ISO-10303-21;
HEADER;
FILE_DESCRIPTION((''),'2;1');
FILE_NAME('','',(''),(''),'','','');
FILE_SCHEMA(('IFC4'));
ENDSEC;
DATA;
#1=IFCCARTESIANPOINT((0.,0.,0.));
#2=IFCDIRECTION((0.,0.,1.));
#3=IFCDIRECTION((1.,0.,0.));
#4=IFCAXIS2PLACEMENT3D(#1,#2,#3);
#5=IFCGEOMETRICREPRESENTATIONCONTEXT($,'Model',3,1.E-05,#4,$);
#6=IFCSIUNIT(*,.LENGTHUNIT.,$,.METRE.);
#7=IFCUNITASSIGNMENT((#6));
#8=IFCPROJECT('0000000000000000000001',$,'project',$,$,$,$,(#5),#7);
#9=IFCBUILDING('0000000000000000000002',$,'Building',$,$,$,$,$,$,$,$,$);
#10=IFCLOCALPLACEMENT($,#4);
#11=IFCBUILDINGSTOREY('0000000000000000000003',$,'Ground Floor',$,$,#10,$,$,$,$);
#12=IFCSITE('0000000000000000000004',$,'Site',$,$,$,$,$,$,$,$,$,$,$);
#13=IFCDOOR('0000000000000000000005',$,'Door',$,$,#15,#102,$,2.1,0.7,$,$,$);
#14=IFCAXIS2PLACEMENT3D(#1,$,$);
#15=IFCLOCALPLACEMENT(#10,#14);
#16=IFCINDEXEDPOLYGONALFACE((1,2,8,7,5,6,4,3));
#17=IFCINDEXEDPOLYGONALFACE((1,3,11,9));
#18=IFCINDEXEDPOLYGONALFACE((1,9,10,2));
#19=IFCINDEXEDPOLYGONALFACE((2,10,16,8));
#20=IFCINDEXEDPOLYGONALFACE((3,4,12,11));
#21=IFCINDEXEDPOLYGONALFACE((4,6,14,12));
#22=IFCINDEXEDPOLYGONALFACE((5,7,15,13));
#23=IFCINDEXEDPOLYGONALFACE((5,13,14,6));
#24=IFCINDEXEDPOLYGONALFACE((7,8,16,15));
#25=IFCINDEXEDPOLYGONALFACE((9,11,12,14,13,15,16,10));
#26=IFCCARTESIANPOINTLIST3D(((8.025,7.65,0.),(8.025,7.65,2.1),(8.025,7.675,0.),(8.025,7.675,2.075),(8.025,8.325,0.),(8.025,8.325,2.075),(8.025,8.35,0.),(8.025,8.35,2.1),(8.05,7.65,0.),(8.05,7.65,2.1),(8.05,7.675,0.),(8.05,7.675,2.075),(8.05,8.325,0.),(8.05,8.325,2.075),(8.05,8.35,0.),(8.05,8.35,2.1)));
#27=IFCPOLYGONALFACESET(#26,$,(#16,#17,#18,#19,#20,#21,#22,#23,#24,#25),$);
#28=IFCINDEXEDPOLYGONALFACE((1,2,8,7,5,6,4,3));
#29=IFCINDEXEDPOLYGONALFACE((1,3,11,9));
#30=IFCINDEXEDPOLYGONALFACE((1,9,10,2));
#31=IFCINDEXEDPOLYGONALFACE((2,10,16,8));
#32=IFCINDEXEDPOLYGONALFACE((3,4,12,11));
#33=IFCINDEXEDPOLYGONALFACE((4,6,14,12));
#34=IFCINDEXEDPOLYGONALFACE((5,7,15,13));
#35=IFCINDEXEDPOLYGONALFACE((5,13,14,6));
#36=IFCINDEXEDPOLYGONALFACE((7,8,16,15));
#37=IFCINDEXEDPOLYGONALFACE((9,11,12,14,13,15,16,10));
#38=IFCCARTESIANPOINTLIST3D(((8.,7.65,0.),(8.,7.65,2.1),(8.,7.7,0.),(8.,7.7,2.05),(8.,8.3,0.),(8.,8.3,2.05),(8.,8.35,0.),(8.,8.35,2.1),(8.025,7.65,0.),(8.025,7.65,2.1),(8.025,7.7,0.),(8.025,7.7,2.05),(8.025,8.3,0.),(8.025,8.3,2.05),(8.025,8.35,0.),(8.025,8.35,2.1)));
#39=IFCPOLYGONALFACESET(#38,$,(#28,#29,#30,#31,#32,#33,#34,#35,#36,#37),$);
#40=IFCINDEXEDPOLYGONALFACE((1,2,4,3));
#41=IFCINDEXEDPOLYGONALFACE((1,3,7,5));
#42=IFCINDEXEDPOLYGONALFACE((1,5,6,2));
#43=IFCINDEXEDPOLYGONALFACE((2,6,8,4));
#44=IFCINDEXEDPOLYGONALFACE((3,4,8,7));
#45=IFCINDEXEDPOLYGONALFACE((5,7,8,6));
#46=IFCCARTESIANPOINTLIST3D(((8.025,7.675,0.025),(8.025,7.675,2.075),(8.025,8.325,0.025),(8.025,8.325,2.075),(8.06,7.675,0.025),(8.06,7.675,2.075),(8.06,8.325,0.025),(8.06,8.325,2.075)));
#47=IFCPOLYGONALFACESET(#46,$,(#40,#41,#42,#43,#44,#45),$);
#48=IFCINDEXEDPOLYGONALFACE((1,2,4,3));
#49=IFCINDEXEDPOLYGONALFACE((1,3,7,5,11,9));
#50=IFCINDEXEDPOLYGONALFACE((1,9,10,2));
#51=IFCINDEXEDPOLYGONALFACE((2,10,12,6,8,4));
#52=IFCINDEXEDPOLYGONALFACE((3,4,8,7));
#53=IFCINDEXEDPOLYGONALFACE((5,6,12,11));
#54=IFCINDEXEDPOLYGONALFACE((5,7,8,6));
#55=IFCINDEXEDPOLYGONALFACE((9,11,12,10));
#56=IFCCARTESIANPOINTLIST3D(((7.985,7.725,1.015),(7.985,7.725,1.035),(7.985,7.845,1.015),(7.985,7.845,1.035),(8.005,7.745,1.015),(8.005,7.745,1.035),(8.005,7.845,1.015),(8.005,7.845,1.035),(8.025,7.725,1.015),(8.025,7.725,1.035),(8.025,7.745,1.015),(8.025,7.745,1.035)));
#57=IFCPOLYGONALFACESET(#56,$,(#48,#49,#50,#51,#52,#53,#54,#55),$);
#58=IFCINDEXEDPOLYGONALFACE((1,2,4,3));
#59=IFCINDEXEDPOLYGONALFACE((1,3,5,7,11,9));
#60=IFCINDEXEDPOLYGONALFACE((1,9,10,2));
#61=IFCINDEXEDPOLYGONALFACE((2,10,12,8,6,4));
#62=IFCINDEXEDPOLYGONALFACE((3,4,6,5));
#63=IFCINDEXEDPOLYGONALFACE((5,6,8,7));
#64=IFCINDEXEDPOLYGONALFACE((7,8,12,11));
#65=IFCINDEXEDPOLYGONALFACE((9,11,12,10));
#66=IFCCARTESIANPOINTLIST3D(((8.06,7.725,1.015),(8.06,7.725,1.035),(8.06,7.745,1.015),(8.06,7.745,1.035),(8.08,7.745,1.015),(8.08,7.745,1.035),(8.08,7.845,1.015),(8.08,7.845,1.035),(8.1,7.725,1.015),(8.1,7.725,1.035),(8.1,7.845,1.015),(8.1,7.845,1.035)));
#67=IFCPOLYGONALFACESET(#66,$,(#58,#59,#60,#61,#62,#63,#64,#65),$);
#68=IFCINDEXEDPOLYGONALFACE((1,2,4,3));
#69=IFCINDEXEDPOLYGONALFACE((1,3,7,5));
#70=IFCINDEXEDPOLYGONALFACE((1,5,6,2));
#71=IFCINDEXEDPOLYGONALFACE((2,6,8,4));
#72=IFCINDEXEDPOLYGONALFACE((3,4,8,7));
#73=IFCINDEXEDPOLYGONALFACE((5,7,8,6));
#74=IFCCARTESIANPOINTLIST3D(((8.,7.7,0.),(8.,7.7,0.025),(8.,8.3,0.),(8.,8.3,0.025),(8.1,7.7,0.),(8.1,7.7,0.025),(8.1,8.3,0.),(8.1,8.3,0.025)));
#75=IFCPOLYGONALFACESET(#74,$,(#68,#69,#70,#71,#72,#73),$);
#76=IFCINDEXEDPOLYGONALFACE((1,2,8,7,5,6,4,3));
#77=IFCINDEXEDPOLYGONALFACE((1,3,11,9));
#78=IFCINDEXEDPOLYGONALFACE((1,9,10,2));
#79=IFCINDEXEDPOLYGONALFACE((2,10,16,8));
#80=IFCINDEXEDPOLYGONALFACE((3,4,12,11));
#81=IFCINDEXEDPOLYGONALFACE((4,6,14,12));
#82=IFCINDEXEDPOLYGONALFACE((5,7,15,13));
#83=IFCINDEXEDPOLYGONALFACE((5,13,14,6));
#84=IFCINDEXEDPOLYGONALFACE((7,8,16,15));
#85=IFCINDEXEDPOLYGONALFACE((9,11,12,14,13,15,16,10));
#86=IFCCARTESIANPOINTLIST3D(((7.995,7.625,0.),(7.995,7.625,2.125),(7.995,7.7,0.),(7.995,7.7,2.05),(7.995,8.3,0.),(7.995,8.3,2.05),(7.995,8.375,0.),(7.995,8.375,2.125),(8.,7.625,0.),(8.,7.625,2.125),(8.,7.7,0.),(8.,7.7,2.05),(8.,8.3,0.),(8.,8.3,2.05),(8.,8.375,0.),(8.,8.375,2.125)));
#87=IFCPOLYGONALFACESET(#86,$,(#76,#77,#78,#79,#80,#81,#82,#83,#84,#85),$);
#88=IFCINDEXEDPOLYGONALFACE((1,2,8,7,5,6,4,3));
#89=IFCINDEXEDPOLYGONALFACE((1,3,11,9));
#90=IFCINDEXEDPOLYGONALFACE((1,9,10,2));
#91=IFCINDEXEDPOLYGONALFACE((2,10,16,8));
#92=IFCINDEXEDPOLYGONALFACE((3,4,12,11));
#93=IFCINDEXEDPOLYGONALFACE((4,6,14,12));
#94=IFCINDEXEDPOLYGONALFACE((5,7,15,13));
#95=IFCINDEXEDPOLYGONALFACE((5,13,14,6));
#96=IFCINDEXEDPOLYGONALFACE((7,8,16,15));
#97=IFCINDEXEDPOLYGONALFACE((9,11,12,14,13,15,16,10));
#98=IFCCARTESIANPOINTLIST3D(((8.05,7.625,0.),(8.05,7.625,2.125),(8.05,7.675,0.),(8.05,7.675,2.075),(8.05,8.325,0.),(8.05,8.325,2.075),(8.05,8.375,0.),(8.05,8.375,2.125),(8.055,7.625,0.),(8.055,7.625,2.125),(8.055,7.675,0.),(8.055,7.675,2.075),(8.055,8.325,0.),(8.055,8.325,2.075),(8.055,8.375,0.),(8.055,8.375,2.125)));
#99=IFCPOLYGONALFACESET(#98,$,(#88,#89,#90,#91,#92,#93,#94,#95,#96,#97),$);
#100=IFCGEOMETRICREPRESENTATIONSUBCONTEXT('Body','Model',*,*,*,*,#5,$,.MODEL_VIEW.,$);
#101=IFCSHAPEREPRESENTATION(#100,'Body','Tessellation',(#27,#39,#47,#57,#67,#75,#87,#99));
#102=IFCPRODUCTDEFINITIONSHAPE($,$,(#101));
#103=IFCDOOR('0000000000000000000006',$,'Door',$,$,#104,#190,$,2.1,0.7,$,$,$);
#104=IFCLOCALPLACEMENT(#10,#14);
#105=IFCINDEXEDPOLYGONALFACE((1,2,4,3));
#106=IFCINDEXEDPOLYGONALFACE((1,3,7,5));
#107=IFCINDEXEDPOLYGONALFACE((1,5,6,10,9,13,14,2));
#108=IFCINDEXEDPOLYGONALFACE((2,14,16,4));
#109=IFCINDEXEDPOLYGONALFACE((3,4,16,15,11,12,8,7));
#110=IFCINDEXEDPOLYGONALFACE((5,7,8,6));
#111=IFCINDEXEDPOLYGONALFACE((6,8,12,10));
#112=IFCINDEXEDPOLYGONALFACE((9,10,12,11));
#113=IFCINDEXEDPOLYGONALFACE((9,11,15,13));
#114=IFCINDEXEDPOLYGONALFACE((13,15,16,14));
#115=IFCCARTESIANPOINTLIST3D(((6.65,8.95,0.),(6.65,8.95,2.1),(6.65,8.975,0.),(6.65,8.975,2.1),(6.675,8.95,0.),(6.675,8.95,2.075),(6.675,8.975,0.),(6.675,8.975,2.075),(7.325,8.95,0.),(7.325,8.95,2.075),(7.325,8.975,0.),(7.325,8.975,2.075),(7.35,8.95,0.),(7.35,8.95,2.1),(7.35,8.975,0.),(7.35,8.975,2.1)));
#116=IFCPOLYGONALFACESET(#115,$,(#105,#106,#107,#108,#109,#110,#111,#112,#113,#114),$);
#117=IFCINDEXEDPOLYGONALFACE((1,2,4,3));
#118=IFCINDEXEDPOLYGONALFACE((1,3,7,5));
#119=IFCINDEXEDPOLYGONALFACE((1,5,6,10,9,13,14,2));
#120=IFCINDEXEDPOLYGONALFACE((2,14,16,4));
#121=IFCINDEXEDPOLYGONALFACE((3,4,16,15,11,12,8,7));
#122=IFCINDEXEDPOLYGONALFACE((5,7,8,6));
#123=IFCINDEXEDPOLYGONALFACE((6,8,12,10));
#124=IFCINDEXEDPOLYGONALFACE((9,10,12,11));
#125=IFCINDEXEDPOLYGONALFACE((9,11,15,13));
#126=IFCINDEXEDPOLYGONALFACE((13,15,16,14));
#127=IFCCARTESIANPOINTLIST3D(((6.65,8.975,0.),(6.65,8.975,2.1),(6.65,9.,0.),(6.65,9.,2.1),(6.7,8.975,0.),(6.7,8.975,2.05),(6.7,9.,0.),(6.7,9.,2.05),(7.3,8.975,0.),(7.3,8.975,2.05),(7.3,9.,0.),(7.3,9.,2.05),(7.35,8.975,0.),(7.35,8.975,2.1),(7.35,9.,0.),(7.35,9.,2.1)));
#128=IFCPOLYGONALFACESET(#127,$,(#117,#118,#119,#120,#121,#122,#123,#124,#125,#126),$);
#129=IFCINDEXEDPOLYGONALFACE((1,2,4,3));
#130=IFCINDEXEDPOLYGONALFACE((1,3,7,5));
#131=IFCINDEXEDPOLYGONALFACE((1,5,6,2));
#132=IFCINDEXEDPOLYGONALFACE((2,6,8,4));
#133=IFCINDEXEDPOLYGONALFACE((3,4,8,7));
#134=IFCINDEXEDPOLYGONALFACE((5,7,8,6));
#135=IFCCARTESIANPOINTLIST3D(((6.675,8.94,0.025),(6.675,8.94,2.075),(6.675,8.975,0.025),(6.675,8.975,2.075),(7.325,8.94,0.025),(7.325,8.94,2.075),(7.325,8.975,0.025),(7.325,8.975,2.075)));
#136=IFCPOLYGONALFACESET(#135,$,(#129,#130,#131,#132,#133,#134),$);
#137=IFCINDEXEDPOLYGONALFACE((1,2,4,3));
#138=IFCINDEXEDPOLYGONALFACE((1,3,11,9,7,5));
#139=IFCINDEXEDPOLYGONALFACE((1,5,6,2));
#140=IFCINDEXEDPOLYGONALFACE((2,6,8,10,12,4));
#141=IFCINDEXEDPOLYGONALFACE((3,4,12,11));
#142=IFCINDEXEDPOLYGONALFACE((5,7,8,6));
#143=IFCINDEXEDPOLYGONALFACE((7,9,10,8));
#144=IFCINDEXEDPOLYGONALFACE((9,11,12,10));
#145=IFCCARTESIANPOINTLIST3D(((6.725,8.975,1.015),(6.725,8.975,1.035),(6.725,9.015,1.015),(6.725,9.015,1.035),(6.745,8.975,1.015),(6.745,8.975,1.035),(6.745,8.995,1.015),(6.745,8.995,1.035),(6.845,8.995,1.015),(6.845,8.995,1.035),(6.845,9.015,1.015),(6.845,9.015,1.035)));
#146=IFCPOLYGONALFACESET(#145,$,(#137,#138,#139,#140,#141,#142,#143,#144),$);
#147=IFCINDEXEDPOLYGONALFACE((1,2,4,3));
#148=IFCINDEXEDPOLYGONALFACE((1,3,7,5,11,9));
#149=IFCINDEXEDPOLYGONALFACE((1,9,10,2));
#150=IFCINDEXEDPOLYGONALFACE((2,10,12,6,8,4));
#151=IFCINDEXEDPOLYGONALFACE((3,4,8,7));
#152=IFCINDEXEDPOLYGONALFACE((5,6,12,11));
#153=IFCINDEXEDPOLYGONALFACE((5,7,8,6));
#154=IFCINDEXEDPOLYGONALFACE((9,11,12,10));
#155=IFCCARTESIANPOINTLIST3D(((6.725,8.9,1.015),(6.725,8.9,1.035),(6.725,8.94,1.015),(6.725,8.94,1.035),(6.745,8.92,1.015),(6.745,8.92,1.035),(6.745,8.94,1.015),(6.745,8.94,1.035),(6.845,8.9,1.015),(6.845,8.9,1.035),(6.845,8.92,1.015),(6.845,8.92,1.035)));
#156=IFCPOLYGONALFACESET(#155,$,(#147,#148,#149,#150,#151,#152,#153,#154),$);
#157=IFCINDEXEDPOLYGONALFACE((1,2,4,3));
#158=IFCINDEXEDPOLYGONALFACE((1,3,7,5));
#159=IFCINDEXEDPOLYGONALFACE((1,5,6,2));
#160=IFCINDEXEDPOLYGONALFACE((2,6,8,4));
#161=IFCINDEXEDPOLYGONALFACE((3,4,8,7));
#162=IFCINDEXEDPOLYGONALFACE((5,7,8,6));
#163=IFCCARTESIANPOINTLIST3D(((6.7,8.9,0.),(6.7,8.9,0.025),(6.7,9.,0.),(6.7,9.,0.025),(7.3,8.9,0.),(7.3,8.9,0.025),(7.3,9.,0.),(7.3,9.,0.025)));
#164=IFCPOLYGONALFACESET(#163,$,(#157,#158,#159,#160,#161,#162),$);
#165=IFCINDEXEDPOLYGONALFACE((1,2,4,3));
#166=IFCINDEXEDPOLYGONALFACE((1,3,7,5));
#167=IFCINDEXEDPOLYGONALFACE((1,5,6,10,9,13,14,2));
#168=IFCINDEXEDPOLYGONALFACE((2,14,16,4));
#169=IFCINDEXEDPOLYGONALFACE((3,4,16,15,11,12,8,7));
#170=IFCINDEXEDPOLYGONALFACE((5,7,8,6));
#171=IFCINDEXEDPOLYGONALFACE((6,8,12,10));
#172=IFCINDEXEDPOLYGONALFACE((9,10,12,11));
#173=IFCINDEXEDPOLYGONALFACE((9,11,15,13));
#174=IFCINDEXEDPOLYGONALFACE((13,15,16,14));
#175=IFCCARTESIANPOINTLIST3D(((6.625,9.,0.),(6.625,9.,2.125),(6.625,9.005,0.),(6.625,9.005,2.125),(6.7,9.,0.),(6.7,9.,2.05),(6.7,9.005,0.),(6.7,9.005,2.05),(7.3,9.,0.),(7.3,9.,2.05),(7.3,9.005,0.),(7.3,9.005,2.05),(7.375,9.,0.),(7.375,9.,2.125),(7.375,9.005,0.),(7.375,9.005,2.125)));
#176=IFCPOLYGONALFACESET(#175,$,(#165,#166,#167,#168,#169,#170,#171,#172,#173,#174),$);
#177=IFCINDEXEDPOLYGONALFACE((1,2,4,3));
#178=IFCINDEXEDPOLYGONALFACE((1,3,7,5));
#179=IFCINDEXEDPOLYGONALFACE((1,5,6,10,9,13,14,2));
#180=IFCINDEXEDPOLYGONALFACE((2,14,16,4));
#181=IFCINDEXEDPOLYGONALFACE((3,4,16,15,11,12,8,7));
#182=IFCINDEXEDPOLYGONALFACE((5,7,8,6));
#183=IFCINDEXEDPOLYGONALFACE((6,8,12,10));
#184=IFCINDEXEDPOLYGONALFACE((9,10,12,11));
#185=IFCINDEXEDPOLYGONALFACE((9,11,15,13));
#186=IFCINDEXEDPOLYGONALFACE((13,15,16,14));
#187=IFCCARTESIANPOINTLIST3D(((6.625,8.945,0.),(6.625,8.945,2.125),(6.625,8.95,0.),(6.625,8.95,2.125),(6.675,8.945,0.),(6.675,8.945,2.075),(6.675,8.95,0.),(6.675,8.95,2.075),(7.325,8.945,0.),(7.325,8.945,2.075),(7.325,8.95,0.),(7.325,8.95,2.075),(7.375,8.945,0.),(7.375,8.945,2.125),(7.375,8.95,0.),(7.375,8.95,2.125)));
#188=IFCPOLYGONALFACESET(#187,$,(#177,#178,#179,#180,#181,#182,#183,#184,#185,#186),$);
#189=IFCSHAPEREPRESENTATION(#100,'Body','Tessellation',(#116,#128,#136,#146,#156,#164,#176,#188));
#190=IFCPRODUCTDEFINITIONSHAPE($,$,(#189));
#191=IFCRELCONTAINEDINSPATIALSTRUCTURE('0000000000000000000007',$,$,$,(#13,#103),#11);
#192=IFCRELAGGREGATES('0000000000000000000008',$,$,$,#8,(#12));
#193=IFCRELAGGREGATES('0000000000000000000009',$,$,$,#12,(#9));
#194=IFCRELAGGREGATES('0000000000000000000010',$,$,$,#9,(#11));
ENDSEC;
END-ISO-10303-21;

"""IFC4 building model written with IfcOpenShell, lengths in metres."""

from ifc_helpers import new_model, si_unit, frame, origin_with_axes, place, context, subcontext, project, spatial, line, indexed_curve, outline, extrude, element, save


model = new_model("IFC4")

# Units and contexts
model_context = context("Model", 3, precision=1e-05, world=origin_with_axes())
body_context = subcontext(model_context, "Body", "Model", "MODEL_VIEW")
ifc_project = project(units=[si_unit("LENGTHUNIT", "METRE")], contexts=[model_context])

# Site, building, storey
site = spatial("IfcSite", under=ifc_project, Name="Site")
building = spatial("IfcBuilding", under=site, Name="Building")
storey_placement = place(None, origin_with_axes())
storey = spatial("IfcBuildingStorey", under=building, at=storey_placement, Name="Ground Floor")

# Doors
door_1_placement = place(storey_placement, frame((8.0, 8.35, 0.0), z_axis=(0.0, 0.0, 1.0), x_axis=(0.0, -1.0, 0.0)))
element("IfcDoor", 1, at=door_1_placement, inside=storey, Name="Door", OverallHeight=2.1, OverallWidth=0.7, context=body_context, shape_type="SweptSolid", body=[
    extrude(outline(indexed_curve([(0.0, 0.0), (0.0, 2.1), (0.7, 2.1), (0.7, 0.0), (0.675, 0.0), (0.675, 2.075), (0.025, 2.075), (0.025, 0.0)], segments=[line(1, 2, 3, 4, 5, 6, 7, 8, 1)])), frame((0.0, 0.025, 0.0), z_axis=(0.0, -1.0, 0.0), x_axis=(1.0, 0.0, 0.0)), (0.0, 0.0, -1.0), 0.025),
    extrude(outline(indexed_curve([(0.0, 0.0), (0.0, 2.1), (0.7, 2.1), (0.7, 0.0), (0.65, 0.0), (0.65, 2.05), (0.05, 2.05), (0.05, 0.0)], segments=[line(1, 2, 3, 4, 5, 6, 7, 8, 1)])), frame((0.0, 0.0, 0.0), z_axis=(0.0, -1.0, 0.0), x_axis=(1.0, 0.0, 0.0)), (0.0, 0.0, -1.0), 0.025),
    extrude(outline(indexed_curve([(0.0, 0.0), (0.65, 0.0), (0.65, 0.035), (0.0, 0.035)], segments=[line(1, 2, 3, 4, 1)])), frame((0.025, 0.025, 0.025), z_axis=(0.0, 0.0, 1.0), x_axis=(1.0, 0.0, 0.0)), (0.0, 0.0, 1.0), 2.05),
    extrude(outline(indexed_curve([(0.0, 0.0), (0.0, -0.04), (-0.12, -0.04), (-0.12, -0.02), (-0.02, -0.02), (-0.02, 0.0)], segments=[line(1, 2, 3, 4, 5, 6, 1)])), frame((0.625, 0.025, 1.015), z_axis=(0.0, 0.0, 1.0), x_axis=(1.0, 0.0, 0.0)), (0.0, 0.0, 1.0), 0.02),
    extrude(outline(indexed_curve([(0.0, 0.0), (0.0, 0.04), (-0.12, 0.04), (-0.12, 0.02), (-0.02, 0.02), (-0.02, 0.0)], segments=[line(1, 2, 3, 4, 5, 6, 1)])), frame((0.625, 0.06, 1.015), z_axis=(0.0, 0.0, 1.0), x_axis=(1.0, 0.0, 0.0)), (0.0, 0.0, 1.0), 0.02),
    extrude(outline(indexed_curve([(0.0, 0.0), (0.6, 0.0), (0.6, 0.1), (0.0, 0.1)], segments=[line(1, 2, 3, 4, 1)])), frame((0.05, 0.0, 0.0), z_axis=(0.0, 0.0, 1.0), x_axis=(1.0, 0.0, 0.0)), (0.0, 0.0, 1.0), 0.025),
    extrude(outline(indexed_curve([(0.0, 0.0), (0.0, 2.125), (0.75, 2.125), (0.75, 0.0), (0.675, 0.0), (0.675, 2.05), (0.075, 2.05), (0.075, 0.0)], segments=[line(1, 2, 3, 4, 5, 6, 7, 8, 1)])), frame((-0.025, -0.005, 0.0), z_axis=(0.0, -1.0, 0.0), x_axis=(1.0, 0.0, 0.0)), (0.0, 0.0, -1.0), 0.005),
    extrude(outline(indexed_curve([(0.0, 0.0), (0.0, 2.125), (0.75, 2.125), (0.75, 0.0), (0.7, 0.0), (0.7, 2.075), (0.05, 2.075), (0.05, 0.0)], segments=[line(1, 2, 3, 4, 5, 6, 7, 8, 1)])), frame((-0.025, 0.05, 0.0), z_axis=(0.0, -1.0, 0.0), x_axis=(1.0, 0.0, 0.0)), (0.0, 0.0, -1.0), 0.005),
])
door_2_placement = place(storey_placement, frame((7.35, 9.0, 0.0), z_axis=(0.0, 0.0, 1.0), x_axis=(-1.0, 0.0, 0.0)))
element("IfcDoor", 2, at=door_2_placement, inside=storey, Name="Door", OverallHeight=2.1, OverallWidth=0.7, context=body_context, shape_type="SweptSolid", body=[
    extrude(outline(indexed_curve([(0.0, 0.0), (0.0, 2.1), (0.7, 2.1), (0.7, 0.0), (0.675, 0.0), (0.675, 2.075), (0.025, 2.075), (0.025, 0.0)], segments=[line(1, 2, 3, 4, 5, 6, 7, 8, 1)])), frame((0.0, 0.025, 0.0), z_axis=(0.0, -1.0, 0.0), x_axis=(1.0, 0.0, 0.0)), (0.0, 0.0, -1.0), 0.025),
    extrude(outline(indexed_curve([(0.0, 0.0), (0.0, 2.1), (0.7, 2.1), (0.7, 0.0), (0.65, 0.0), (0.65, 2.05), (0.05, 2.05), (0.05, 0.0)], segments=[line(1, 2, 3, 4, 5, 6, 7, 8, 1)])), frame((0.0, 0.0, 0.0), z_axis=(0.0, -1.0, 0.0), x_axis=(1.0, 0.0, 0.0)), (0.0, 0.0, -1.0), 0.025),
    extrude(outline(indexed_curve([(0.0, 0.0), (0.65, 0.0), (0.65, 0.035), (0.0, 0.035)], segments=[line(1, 2, 3, 4, 1)])), frame((0.025, 0.025, 0.025), z_axis=(0.0, 0.0, 1.0), x_axis=(1.0, 0.0, 0.0)), (0.0, 0.0, 1.0), 2.05),
    extrude(outline(indexed_curve([(0.0, 0.0), (0.0, -0.04), (-0.12, -0.04), (-0.12, -0.02), (-0.02, -0.02), (-0.02, 0.0)], segments=[line(1, 2, 3, 4, 5, 6, 1)])), frame((0.625, 0.025, 1.015), z_axis=(0.0, 0.0, 1.0), x_axis=(1.0, 0.0, 0.0)), (0.0, 0.0, 1.0), 0.02),
    extrude(outline(indexed_curve([(0.0, 0.0), (0.0, 0.04), (-0.12, 0.04), (-0.12, 0.02), (-0.02, 0.02), (-0.02, 0.0)], segments=[line(1, 2, 3, 4, 5, 6, 1)])), frame((0.625, 0.06, 1.015), z_axis=(0.0, 0.0, 1.0), x_axis=(1.0, 0.0, 0.0)), (0.0, 0.0, 1.0), 0.02),
    extrude(outline(indexed_curve([(0.0, 0.0), (0.6, 0.0), (0.6, 0.1), (0.0, 0.1)], segments=[line(1, 2, 3, 4, 1)])), frame((0.05, 0.0, 0.0), z_axis=(0.0, 0.0, 1.0), x_axis=(1.0, 0.0, 0.0)), (0.0, 0.0, 1.0), 0.025),
    extrude(outline(indexed_curve([(0.0, 0.0), (0.0, 2.125), (0.75, 2.125), (0.75, 0.0), (0.675, 0.0), (0.675, 2.05), (0.075, 2.05), (0.075, 0.0)], segments=[line(1, 2, 3, 4, 5, 6, 7, 8, 1)])), frame((-0.025, -0.005, 0.0), z_axis=(0.0, -1.0, 0.0), x_axis=(1.0, 0.0, 0.0)), (0.0, 0.0, -1.0), 0.005),
    extrude(outline(indexed_curve([(0.0, 0.0), (0.0, 2.125), (0.75, 2.125), (0.75, 0.0), (0.7, 0.0), (0.7, 2.075), (0.05, 2.075), (0.05, 0.0)], segments=[line(1, 2, 3, 4, 5, 6, 7, 8, 1)])), frame((-0.025, 0.05, 0.0), z_axis=(0.0, -1.0, 0.0), x_axis=(1.0, 0.0, 0.0)), (0.0, 0.0, -1.0), 0.005),
])

save(model, "model.ifc")
